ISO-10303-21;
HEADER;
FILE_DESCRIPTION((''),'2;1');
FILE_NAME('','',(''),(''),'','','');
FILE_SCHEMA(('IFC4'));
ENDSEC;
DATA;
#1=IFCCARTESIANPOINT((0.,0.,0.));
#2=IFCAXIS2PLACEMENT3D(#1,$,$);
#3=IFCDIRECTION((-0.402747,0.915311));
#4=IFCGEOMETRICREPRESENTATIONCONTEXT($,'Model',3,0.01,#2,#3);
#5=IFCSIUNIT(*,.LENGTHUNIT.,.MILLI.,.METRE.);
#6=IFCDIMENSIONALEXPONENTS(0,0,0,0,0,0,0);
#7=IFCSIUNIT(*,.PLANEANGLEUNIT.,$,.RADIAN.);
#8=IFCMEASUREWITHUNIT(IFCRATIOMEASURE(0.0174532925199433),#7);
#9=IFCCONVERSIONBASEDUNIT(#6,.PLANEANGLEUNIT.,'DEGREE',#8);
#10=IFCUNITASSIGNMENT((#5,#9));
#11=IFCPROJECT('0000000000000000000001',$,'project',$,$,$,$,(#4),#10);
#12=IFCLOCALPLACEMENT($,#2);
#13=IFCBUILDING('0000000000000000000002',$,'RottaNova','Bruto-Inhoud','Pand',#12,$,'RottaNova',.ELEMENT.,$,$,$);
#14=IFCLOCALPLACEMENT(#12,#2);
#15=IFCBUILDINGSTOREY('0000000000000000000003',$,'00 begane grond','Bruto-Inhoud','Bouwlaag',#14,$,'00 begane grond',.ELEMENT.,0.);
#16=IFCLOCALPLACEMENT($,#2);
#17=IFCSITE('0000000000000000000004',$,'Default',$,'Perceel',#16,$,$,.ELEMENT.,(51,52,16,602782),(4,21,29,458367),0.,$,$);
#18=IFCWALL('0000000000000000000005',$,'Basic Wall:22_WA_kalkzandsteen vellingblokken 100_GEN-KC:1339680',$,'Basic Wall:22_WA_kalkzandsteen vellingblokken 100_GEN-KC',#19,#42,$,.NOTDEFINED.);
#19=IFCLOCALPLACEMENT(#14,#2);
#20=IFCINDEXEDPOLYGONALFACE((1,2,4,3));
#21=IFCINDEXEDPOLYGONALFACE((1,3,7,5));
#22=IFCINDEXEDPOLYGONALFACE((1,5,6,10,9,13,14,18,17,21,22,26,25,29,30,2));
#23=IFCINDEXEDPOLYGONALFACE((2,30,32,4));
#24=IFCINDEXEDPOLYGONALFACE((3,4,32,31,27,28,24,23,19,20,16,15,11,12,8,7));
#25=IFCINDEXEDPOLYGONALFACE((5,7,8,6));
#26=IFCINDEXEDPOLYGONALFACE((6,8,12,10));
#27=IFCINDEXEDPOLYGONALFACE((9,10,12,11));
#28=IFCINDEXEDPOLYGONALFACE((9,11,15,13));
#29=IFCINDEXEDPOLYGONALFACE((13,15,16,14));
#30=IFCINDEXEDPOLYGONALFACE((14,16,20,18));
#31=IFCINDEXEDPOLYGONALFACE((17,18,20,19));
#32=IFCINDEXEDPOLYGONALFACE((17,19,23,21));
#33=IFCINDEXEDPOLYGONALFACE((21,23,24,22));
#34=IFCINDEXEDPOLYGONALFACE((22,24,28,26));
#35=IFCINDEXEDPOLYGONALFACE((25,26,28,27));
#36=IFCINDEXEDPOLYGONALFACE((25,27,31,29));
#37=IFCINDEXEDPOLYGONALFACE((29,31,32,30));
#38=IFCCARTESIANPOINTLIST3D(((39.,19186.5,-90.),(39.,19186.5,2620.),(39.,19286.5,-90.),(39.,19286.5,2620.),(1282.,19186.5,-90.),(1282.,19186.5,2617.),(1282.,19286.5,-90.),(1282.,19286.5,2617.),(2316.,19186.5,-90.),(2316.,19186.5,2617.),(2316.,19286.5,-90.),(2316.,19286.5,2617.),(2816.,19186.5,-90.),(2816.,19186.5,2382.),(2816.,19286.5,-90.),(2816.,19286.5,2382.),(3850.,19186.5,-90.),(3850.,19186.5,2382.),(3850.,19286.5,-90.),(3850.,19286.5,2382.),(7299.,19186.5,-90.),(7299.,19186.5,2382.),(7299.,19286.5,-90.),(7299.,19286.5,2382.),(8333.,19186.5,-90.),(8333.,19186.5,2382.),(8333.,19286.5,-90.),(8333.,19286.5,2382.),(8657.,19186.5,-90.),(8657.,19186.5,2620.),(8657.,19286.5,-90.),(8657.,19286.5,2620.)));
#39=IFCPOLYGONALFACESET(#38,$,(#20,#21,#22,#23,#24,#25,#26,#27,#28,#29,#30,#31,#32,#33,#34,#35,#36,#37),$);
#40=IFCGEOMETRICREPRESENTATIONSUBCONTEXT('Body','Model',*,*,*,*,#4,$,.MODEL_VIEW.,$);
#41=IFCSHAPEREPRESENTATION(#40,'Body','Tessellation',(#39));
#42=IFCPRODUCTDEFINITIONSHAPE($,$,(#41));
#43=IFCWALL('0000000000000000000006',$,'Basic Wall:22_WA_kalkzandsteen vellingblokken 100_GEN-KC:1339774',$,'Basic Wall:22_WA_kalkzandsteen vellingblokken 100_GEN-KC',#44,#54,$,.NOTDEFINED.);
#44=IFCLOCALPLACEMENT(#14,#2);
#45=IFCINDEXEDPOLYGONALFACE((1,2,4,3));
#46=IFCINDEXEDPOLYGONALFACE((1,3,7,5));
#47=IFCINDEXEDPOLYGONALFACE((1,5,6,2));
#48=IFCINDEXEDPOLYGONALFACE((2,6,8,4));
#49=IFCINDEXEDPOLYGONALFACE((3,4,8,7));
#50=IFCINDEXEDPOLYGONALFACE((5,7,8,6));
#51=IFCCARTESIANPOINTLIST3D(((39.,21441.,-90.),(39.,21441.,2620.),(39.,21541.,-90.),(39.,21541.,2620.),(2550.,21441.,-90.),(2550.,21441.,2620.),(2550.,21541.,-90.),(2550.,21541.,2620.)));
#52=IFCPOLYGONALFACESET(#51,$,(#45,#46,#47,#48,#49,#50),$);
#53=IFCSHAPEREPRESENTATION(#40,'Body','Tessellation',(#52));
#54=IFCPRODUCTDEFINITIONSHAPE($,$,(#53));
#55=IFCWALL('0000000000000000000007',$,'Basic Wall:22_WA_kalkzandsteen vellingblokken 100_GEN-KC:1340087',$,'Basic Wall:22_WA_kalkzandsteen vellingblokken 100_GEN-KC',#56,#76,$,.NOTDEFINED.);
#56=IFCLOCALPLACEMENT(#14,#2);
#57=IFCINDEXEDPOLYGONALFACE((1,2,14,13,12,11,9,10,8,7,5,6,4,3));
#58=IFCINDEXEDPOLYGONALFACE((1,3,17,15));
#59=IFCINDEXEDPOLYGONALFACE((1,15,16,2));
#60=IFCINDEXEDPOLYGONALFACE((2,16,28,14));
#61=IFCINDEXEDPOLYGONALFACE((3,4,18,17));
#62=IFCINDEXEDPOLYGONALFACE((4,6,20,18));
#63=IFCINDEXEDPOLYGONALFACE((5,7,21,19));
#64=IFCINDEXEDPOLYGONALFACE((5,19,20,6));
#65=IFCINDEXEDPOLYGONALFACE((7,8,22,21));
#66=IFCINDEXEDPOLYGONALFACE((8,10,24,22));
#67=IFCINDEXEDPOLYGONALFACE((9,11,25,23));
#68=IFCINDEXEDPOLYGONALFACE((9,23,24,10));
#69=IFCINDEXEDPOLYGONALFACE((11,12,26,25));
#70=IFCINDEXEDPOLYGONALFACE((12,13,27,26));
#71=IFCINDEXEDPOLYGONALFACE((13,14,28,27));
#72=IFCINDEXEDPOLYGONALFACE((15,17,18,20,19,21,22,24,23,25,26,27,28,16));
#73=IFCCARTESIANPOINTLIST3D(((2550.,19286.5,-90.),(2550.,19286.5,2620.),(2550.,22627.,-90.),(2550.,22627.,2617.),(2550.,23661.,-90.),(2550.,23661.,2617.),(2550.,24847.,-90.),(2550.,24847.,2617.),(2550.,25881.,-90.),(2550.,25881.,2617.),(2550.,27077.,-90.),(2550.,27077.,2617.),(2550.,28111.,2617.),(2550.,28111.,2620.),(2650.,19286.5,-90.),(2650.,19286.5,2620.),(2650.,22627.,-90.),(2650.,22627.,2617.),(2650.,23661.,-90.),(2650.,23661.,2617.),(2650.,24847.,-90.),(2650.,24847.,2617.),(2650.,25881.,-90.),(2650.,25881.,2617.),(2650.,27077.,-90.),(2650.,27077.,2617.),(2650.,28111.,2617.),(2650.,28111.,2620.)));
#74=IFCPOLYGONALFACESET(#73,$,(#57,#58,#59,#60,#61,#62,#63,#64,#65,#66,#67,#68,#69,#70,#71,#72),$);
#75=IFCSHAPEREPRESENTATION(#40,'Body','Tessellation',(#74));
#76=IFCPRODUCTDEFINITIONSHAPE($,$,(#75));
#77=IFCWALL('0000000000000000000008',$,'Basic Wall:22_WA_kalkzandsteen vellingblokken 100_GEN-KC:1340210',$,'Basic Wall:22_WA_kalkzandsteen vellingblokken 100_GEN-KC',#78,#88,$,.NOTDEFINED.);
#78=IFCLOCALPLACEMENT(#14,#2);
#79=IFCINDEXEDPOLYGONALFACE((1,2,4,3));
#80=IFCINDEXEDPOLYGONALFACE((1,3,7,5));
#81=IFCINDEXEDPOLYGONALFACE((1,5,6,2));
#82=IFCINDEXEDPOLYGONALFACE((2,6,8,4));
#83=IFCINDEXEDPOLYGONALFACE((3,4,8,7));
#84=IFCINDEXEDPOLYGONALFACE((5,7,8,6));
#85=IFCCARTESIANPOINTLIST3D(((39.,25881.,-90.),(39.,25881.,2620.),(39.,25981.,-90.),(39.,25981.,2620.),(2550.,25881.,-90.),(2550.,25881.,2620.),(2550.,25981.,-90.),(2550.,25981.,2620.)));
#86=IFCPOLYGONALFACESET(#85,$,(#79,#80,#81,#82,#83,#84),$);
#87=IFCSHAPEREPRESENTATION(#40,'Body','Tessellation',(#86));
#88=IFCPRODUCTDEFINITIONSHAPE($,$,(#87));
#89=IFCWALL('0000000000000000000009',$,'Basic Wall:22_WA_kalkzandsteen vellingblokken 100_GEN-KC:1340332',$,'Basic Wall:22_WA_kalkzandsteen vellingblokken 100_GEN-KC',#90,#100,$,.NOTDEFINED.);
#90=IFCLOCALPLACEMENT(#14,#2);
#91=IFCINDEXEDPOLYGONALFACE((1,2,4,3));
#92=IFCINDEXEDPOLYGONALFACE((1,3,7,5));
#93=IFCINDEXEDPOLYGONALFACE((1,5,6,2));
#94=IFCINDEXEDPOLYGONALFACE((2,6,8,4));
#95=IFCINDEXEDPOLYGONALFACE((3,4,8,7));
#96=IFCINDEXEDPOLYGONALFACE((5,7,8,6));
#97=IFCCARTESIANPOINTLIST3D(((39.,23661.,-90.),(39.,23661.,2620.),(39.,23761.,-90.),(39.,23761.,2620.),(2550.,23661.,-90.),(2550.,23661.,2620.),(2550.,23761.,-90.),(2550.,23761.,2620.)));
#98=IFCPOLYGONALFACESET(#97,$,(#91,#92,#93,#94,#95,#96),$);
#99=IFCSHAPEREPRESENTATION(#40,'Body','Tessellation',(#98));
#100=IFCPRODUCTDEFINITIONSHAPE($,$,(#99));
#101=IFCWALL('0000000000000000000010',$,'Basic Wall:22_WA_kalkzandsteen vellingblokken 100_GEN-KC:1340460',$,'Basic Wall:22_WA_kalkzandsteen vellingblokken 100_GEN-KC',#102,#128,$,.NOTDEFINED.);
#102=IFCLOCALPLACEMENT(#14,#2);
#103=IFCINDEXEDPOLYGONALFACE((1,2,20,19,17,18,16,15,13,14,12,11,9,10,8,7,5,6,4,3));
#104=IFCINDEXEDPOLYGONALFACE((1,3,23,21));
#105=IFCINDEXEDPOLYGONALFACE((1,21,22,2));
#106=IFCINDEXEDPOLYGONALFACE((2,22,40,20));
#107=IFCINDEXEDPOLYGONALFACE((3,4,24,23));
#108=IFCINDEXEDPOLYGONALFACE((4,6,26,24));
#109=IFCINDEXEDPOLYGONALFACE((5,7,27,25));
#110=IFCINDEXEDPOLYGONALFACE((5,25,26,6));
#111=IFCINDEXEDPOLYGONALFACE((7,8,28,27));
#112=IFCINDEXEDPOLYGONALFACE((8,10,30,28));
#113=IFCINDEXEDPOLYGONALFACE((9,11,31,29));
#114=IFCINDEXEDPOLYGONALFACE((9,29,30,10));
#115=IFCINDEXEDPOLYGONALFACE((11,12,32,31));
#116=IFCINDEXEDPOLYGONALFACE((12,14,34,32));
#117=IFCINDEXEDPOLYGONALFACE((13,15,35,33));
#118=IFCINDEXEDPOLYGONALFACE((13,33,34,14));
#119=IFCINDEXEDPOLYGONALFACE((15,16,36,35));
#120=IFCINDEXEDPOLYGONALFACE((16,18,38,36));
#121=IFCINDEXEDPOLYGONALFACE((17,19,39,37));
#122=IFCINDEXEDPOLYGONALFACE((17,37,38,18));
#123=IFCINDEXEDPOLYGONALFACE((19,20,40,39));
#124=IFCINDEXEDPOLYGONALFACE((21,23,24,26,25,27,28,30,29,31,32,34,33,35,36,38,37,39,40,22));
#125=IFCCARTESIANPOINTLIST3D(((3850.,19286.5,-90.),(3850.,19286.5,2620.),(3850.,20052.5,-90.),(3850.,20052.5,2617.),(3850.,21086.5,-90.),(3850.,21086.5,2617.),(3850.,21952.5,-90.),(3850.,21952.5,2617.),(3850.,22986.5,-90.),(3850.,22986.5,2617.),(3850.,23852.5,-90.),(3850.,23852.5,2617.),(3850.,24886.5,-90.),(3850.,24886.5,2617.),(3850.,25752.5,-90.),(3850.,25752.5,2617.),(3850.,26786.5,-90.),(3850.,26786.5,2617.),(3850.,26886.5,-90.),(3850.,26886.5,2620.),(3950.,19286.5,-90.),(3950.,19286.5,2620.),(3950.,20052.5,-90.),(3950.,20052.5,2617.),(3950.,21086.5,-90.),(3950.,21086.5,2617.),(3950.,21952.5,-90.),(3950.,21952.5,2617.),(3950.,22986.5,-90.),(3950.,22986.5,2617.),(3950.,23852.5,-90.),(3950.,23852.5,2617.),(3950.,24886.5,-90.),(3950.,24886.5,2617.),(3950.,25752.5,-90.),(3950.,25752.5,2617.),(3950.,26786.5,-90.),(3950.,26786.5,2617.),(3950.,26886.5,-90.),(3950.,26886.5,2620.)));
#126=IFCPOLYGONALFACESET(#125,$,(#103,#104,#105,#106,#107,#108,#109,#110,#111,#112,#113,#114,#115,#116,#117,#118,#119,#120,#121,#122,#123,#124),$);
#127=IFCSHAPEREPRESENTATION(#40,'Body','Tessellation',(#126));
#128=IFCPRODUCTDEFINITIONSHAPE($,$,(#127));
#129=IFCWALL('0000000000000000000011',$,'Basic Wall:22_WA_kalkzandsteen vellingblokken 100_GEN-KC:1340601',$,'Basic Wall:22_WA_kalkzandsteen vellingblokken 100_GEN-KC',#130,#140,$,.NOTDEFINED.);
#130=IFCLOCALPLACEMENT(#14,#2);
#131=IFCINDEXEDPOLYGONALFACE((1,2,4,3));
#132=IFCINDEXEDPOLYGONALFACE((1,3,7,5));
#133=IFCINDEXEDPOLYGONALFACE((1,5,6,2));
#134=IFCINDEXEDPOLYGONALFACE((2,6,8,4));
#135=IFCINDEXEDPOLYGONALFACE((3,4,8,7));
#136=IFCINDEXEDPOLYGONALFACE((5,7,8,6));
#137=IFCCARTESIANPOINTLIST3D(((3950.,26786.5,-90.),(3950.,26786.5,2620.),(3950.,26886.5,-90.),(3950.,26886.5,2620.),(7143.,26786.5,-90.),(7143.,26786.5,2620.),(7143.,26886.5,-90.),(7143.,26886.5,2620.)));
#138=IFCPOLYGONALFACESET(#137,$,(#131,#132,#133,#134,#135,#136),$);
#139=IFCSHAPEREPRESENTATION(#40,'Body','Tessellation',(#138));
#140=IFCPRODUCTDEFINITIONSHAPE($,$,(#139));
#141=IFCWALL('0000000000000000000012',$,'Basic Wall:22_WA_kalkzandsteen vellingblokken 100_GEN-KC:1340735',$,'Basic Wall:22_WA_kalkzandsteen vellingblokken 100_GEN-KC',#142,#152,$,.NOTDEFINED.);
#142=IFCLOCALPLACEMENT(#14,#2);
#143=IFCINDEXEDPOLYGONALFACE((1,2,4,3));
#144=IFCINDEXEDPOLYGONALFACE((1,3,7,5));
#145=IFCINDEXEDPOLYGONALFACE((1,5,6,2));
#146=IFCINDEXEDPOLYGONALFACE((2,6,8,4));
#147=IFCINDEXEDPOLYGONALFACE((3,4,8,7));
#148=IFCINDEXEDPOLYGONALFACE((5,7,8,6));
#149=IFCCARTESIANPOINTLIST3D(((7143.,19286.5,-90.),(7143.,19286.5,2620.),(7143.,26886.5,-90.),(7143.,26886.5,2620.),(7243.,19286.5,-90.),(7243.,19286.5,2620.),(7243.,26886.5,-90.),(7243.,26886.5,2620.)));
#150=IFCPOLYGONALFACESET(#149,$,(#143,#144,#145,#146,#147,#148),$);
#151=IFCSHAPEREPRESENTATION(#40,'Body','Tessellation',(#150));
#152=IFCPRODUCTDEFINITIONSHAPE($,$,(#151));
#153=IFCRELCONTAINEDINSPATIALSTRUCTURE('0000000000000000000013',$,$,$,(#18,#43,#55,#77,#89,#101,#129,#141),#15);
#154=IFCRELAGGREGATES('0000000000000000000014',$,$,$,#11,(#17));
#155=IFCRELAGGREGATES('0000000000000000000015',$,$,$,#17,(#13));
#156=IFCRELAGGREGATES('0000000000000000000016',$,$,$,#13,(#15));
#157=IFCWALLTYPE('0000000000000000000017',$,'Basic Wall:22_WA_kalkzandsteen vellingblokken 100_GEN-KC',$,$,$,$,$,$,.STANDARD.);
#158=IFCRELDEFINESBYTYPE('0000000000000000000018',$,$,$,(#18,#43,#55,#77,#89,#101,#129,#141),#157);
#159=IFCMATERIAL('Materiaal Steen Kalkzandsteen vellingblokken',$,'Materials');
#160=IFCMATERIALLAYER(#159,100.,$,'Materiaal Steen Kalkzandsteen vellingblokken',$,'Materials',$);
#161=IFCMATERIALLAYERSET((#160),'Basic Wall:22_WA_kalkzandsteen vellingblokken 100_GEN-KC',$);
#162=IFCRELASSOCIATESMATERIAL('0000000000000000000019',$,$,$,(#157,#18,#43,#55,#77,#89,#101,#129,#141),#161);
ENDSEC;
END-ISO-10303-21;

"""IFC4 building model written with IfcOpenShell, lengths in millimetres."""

from ifc_helpers import new_model, entity, si_unit, converted_unit, direction, frame, frame_2d, origin, place, context, subcontext, project, spatial, rectangle, extrude, material, layer, layer_set, type_object, element, save


model = new_model("IFC4")

# Units and contexts
model_context = context("Model", 3, precision=0.01, world=origin(), true_north=direction((-0.402747, 0.915311)))
body_context = subcontext(model_context, "Body", "Model", "MODEL_VIEW")
ifc_project = project(units=[si_unit("LENGTHUNIT", "METRE", prefix="MILLI"), converted_unit("PLANEANGLEUNIT", "DEGREE", entity("IfcRatioMeasure", 0.0174532925199433), si_unit("PLANEANGLEUNIT", "RADIAN"), dimensions=[0, 0, 0, 0, 0, 0, 0])], contexts=[model_context])

# Site, building, storey
site_placement = place(None, origin())
site = spatial("IfcSite", under=ifc_project, at=site_placement, Name="Default", ObjectType="Perceel", CompositionType="ELEMENT", RefLatitude=(51, 52, 16, 602782), RefLongitude=(4, 21, 29, 458367), RefElevation=0.0)
building_placement = place(None, origin())
building = spatial("IfcBuilding", under=site, at=building_placement, Name="RottaNova", Description="Bruto-Inhoud", ObjectType="Pand", LongName="RottaNova", CompositionType="ELEMENT")
storey_placement = place(building_placement, origin())
storey = spatial("IfcBuildingStorey", under=building, at=storey_placement, Name="00 begane grond", Description="Bruto-Inhoud", ObjectType="Bouwlaag", LongName="00 begane grond", CompositionType="ELEMENT", Elevation=0.0)

# Wall, openings
ifc_material_1 = material(Name="Materiaal Steen Kalkzandsteen vellingblokken", Category="Materials")
ifc_layer_1 = layer(ifc_material_1, 100.0, Name="Materiaal Steen Kalkzandsteen vellingblokken", Category="Materials")
ifc_layer_set_1 = layer_set([ifc_layer_1], Name="Basic Wall:22_WA_kalkzandsteen vellingblokken 100_GEN-KC")
wall_type_1 = type_object("IfcWallType", Name="Basic Wall:22_WA_kalkzandsteen vellingblokken 100_GEN-KC", PredefinedType="STANDARD", material=ifc_layer_set_1)
wall_1_placement = place(storey_placement, frame((39.0, 19236.5, -90.0)))
wall_1 = element("IfcWall", 1, at=wall_1_placement, inside=storey, type_object=wall_type_1, material=ifc_layer_set_1, Name="Basic Wall:22_WA_kalkzandsteen vellingblokken 100_GEN-KC:1339680", ObjectType="Basic Wall:22_WA_kalkzandsteen vellingblokken 100_GEN-KC", PredefinedType="NOTDEFINED", context=body_context, shape_type="SweptSolid", body=[
    extrude(rectangle(XDim=8618.0, YDim=100.0, at=frame_2d((4309.0, 0.0), x_axis=(1.0, 0.0))), origin(), (0.0, 0.0, 1.0), 2710.0),
])
opening_1_placement = place(wall_1_placement, frame((1243.0, -50.0, 0.0)))
element("IfcOpeningElement", 2, at=opening_1_placement, cuts=wall_1, PredefinedType="OPENING", context=body_context, shape_type="SweptSolid", body=[
    extrude(rectangle(XDim=2707.0, YDim=1034.0, at=frame_2d((1353.5, 517.0), x_axis=(1.0, 0.0))), frame((0.0, 0.0, 0.0), z_axis=(0.0, 1.0, 0.0), x_axis=(0.0, 0.0, 1.0)), (0.0, 0.0, 1.0), 100.0),
])
opening_2_placement = place(wall_1_placement, frame((2777.0, -50.0, 0.0)))
element("IfcOpeningElement", 3, at=opening_2_placement, cuts=wall_1, PredefinedType="OPENING", context=body_context, shape_type="SweptSolid", body=[
    extrude(rectangle(XDim=2472.0, YDim=1034.0, at=frame_2d((1236.0, 517.0), x_axis=(1.0, 0.0))), frame((0.0, 0.0, 0.0), z_axis=(0.0, 1.0, 0.0), x_axis=(0.0, 0.0, 1.0)), (0.0, 0.0, 1.0), 100.0),
])
opening_3_placement = place(wall_1_placement, frame((7260.0, -50.0, 0.0)))
element("IfcOpeningElement", 4, at=opening_3_placement, cuts=wall_1, PredefinedType="OPENING", context=body_context, shape_type="SweptSolid", body=[
    extrude(rectangle(XDim=2472.0, YDim=1034.0, at=frame_2d((1236.0, 517.0), x_axis=(1.0, 0.0))), frame((0.0, 0.0, 0.0), z_axis=(0.0, 1.0, 0.0), x_axis=(0.0, 0.0, 1.0)), (0.0, 0.0, 1.0), 100.0),
])

# Wall
wall_2_placement = place(storey_placement, frame((39.0, 21491.0, -90.0)))
element("IfcWall", 5, at=wall_2_placement, inside=storey, type_object=wall_type_1, material=ifc_layer_set_1, Name="Basic Wall:22_WA_kalkzandsteen vellingblokken 100_GEN-KC:1339774", ObjectType="Basic Wall:22_WA_kalkzandsteen vellingblokken 100_GEN-KC", PredefinedType="NOTDEFINED", context=body_context, shape_type="SweptSolid", body=[
    extrude(rectangle(XDim=2511.0, YDim=100.0, at=frame_2d((1255.5, 0.0), x_axis=(-1.0, 0.0))), origin(), (0.0, 0.0, 1.0), 2710.0),
])

# Wall, openings
wall_3_placement = place(storey_placement, frame((2600.0, 19286.5, -90.0), z_axis=(0.0, 0.0, 1.0), x_axis=(0.0, 1.0, 0.0)))
wall_3 = element("IfcWall", 6, at=wall_3_placement, inside=storey, type_object=wall_type_1, material=ifc_layer_set_1, Name="Basic Wall:22_WA_kalkzandsteen vellingblokken 100_GEN-KC:1340087", ObjectType="Basic Wall:22_WA_kalkzandsteen vellingblokken 100_GEN-KC", PredefinedType="NOTDEFINED", context=body_context, shape_type="SweptSolid", body=[
    extrude(rectangle(XDim=8824.5, YDim=100.0, at=frame_2d((4412.2, 0.0), x_axis=(1.0, 0.0))), origin(), (0.0, 0.0, 1.0), 2710.0),
])
opening_4_placement = place(wall_3_placement, frame((7790.5, -50.0, 0.0)))
element("IfcOpeningElement", 7, at=opening_4_placement, cuts=wall_3, PredefinedType="OPENING", context=body_context, shape_type="SweptSolid", body=[
    extrude(rectangle(XDim=2707.0, YDim=1034.0, at=frame_2d((1353.5, 517.0), x_axis=(1.0, 0.0))), frame((0.0, 0.0, 0.0), z_axis=(0.0, 1.0, 0.0), x_axis=(0.0, 0.0, 1.0)), (0.0, 0.0, 1.0), 100.0),
])
opening_5_placement = place(wall_3_placement, frame((5560.5, -50.0, 0.0)))
element("IfcOpeningElement", 8, at=opening_5_placement, cuts=wall_3, PredefinedType="OPENING", context=body_context, shape_type="SweptSolid", body=[
    extrude(rectangle(XDim=2707.0, YDim=1034.0, at=frame_2d((1353.5, 517.0), x_axis=(1.0, 0.0))), frame((0.0, 0.0, 0.0), z_axis=(0.0, 1.0, 0.0), x_axis=(0.0, 0.0, 1.0)), (0.0, 0.0, 1.0), 100.0),
])
opening_6_placement = place(wall_3_placement, frame((3340.5, -50.0, 0.0)))
element("IfcOpeningElement", 9, at=opening_6_placement, cuts=wall_3, PredefinedType="OPENING", context=body_context, shape_type="SweptSolid", body=[
    extrude(rectangle(XDim=2707.0, YDim=1034.0, at=frame_2d((1353.5, 517.0), x_axis=(1.0, 0.0))), frame((0.0, 0.0, 0.0), z_axis=(0.0, 1.0, 0.0), x_axis=(0.0, 0.0, 1.0)), (0.0, 0.0, 1.0), 100.0),
])

# Walls
for number, where, z_axis, x_axis, name in (
    (10, (2550.0, 25931.0, -90.0), (0.0, 0.0, 1.0), (-1.0, 0.0, 0.0), "Basic Wall:22_WA_kalkzandsteen vellingblokken 100_GEN-KC:1340210"),
    (11, (2550.0, 23711.0, -90.0), (0.0, 0.0, 1.0), (-1.0, 0.0, 0.0), "Basic Wall:22_WA_kalkzandsteen vellingblokken 100_GEN-KC:1340332"),
):
    element("IfcWall", number, at=place(storey_placement, frame(where, z_axis=z_axis, x_axis=x_axis)), inside=storey, type_object=wall_type_1, material=ifc_layer_set_1, Name=name, ObjectType="Basic Wall:22_WA_kalkzandsteen vellingblokken 100_GEN-KC", PredefinedType="NOTDEFINED", context=body_context, shape_type="SweptSolid", body=[
        extrude(rectangle(XDim=2511.0, YDim=100.0, at=frame_2d((1255.5, 0.0), x_axis=(-1.0, 0.0))), origin(), (0.0, 0.0, 1.0), 2710.0),
    ])

# Wall, openings
wall_4_placement = place(storey_placement, frame((3900.0, 19286.5, -90.0), z_axis=(0.0, 0.0, 1.0), x_axis=(0.0, 1.0, 0.0)))
wall_4 = element("IfcWall", 12, at=wall_4_placement, inside=storey, type_object=wall_type_1, material=ifc_layer_set_1, Name="Basic Wall:22_WA_kalkzandsteen vellingblokken 100_GEN-KC:1340460", ObjectType="Basic Wall:22_WA_kalkzandsteen vellingblokken 100_GEN-KC", PredefinedType="NOTDEFINED", context=body_context, shape_type="SweptSolid", body=[
    extrude(rectangle(XDim=7600.0, YDim=100.0, at=frame_2d((3800.0, 0.0), x_axis=(-1.0, 0.0))), origin(), (0.0, 0.0, 1.0), 2710.0),
])
opening_7_placement = place(wall_4_placement, frame((7500.0, 50.0, 0.0)))
element("IfcOpeningElement", 13, at=opening_7_placement, cuts=wall_4, PredefinedType="OPENING", context=body_context, shape_type="SweptSolid", body=[
    extrude(rectangle(XDim=2707.0, YDim=1034.0, at=frame_2d((1353.5, 517.0), x_axis=(1.0, 0.0))), frame((0.0, 0.0, 0.0), z_axis=(0.0, -1.0, 0.0), x_axis=(0.0, 0.0, 1.0)), (0.0, 0.0, 1.0), 100.0),
])
opening_8_placement = place(wall_4_placement, frame((5600.0, 50.0, 0.0)))
element("IfcOpeningElement", 14, at=opening_8_placement, cuts=wall_4, PredefinedType="OPENING", context=body_context, shape_type="SweptSolid", body=[
    extrude(rectangle(XDim=2707.0, YDim=1034.0, at=frame_2d((1353.5, 517.0), x_axis=(1.0, 0.0))), frame((0.0, 0.0, 0.0), z_axis=(0.0, -1.0, 0.0), x_axis=(0.0, 0.0, 1.0)), (0.0, 0.0, 1.0), 100.0),
])
opening_9_placement = place(wall_4_placement, frame((3700.0, 50.0, 0.0)))
element("IfcOpeningElement", 15, at=opening_9_placement, cuts=wall_4, PredefinedType="OPENING", context=body_context, shape_type="SweptSolid", body=[
    extrude(rectangle(XDim=2707.0, YDim=1034.0, at=frame_2d((1353.5, 517.0), x_axis=(1.0, 0.0))), frame((0.0, 0.0, 0.0), z_axis=(0.0, -1.0, 0.0), x_axis=(0.0, 0.0, 1.0)), (0.0, 0.0, 1.0), 100.0),
])
opening_10_placement = place(wall_4_placement, frame((1800.0, 50.0, 0.0)))
element("IfcOpeningElement", 16, at=opening_10_placement, cuts=wall_4, PredefinedType="OPENING", context=body_context, shape_type="SweptSolid", body=[
    extrude(rectangle(XDim=2707.0, YDim=1034.0, at=frame_2d((1353.5, 517.0), x_axis=(1.0, 0.0))), frame((0.0, 0.0, 0.0), z_axis=(0.0, -1.0, 0.0), x_axis=(0.0, 0.0, 1.0)), (0.0, 0.0, 1.0), 100.0),
])

# Walls
wall_5_placement = place(storey_placement, frame((7143.0, 26836.5, -90.0), z_axis=(0.0, 0.0, 1.0), x_axis=(-1.0, 0.0, 0.0)))
element("IfcWall", 17, at=wall_5_placement, inside=storey, type_object=wall_type_1, material=ifc_layer_set_1, Name="Basic Wall:22_WA_kalkzandsteen vellingblokken 100_GEN-KC:1340601", ObjectType="Basic Wall:22_WA_kalkzandsteen vellingblokken 100_GEN-KC", PredefinedType="NOTDEFINED", context=body_context, shape_type="SweptSolid", body=[
    extrude(rectangle(XDim=3193.0, YDim=100.0, at=frame_2d((1596.5, 0.0), x_axis=(-1.0, 0.0))), origin(), (0.0, 0.0, 1.0), 2710.0),
])
wall_6_placement = place(storey_placement, frame((7193.0, 19286.5, -90.0), z_axis=(0.0, 0.0, 1.0), x_axis=(0.0, 1.0, 0.0)))
element("IfcWall", 18, at=wall_6_placement, inside=storey, type_object=wall_type_1, material=ifc_layer_set_1, Name="Basic Wall:22_WA_kalkzandsteen vellingblokken 100_GEN-KC:1340735", ObjectType="Basic Wall:22_WA_kalkzandsteen vellingblokken 100_GEN-KC", PredefinedType="NOTDEFINED", context=body_context, shape_type="SweptSolid", body=[
    extrude(rectangle(XDim=7600.0, YDim=100.0, at=frame_2d((3800.0, 0.0), x_axis=(-1.0, 0.0))), origin(), (0.0, 0.0, 1.0), 2710.0),
])

save(model, "model.ifc")
